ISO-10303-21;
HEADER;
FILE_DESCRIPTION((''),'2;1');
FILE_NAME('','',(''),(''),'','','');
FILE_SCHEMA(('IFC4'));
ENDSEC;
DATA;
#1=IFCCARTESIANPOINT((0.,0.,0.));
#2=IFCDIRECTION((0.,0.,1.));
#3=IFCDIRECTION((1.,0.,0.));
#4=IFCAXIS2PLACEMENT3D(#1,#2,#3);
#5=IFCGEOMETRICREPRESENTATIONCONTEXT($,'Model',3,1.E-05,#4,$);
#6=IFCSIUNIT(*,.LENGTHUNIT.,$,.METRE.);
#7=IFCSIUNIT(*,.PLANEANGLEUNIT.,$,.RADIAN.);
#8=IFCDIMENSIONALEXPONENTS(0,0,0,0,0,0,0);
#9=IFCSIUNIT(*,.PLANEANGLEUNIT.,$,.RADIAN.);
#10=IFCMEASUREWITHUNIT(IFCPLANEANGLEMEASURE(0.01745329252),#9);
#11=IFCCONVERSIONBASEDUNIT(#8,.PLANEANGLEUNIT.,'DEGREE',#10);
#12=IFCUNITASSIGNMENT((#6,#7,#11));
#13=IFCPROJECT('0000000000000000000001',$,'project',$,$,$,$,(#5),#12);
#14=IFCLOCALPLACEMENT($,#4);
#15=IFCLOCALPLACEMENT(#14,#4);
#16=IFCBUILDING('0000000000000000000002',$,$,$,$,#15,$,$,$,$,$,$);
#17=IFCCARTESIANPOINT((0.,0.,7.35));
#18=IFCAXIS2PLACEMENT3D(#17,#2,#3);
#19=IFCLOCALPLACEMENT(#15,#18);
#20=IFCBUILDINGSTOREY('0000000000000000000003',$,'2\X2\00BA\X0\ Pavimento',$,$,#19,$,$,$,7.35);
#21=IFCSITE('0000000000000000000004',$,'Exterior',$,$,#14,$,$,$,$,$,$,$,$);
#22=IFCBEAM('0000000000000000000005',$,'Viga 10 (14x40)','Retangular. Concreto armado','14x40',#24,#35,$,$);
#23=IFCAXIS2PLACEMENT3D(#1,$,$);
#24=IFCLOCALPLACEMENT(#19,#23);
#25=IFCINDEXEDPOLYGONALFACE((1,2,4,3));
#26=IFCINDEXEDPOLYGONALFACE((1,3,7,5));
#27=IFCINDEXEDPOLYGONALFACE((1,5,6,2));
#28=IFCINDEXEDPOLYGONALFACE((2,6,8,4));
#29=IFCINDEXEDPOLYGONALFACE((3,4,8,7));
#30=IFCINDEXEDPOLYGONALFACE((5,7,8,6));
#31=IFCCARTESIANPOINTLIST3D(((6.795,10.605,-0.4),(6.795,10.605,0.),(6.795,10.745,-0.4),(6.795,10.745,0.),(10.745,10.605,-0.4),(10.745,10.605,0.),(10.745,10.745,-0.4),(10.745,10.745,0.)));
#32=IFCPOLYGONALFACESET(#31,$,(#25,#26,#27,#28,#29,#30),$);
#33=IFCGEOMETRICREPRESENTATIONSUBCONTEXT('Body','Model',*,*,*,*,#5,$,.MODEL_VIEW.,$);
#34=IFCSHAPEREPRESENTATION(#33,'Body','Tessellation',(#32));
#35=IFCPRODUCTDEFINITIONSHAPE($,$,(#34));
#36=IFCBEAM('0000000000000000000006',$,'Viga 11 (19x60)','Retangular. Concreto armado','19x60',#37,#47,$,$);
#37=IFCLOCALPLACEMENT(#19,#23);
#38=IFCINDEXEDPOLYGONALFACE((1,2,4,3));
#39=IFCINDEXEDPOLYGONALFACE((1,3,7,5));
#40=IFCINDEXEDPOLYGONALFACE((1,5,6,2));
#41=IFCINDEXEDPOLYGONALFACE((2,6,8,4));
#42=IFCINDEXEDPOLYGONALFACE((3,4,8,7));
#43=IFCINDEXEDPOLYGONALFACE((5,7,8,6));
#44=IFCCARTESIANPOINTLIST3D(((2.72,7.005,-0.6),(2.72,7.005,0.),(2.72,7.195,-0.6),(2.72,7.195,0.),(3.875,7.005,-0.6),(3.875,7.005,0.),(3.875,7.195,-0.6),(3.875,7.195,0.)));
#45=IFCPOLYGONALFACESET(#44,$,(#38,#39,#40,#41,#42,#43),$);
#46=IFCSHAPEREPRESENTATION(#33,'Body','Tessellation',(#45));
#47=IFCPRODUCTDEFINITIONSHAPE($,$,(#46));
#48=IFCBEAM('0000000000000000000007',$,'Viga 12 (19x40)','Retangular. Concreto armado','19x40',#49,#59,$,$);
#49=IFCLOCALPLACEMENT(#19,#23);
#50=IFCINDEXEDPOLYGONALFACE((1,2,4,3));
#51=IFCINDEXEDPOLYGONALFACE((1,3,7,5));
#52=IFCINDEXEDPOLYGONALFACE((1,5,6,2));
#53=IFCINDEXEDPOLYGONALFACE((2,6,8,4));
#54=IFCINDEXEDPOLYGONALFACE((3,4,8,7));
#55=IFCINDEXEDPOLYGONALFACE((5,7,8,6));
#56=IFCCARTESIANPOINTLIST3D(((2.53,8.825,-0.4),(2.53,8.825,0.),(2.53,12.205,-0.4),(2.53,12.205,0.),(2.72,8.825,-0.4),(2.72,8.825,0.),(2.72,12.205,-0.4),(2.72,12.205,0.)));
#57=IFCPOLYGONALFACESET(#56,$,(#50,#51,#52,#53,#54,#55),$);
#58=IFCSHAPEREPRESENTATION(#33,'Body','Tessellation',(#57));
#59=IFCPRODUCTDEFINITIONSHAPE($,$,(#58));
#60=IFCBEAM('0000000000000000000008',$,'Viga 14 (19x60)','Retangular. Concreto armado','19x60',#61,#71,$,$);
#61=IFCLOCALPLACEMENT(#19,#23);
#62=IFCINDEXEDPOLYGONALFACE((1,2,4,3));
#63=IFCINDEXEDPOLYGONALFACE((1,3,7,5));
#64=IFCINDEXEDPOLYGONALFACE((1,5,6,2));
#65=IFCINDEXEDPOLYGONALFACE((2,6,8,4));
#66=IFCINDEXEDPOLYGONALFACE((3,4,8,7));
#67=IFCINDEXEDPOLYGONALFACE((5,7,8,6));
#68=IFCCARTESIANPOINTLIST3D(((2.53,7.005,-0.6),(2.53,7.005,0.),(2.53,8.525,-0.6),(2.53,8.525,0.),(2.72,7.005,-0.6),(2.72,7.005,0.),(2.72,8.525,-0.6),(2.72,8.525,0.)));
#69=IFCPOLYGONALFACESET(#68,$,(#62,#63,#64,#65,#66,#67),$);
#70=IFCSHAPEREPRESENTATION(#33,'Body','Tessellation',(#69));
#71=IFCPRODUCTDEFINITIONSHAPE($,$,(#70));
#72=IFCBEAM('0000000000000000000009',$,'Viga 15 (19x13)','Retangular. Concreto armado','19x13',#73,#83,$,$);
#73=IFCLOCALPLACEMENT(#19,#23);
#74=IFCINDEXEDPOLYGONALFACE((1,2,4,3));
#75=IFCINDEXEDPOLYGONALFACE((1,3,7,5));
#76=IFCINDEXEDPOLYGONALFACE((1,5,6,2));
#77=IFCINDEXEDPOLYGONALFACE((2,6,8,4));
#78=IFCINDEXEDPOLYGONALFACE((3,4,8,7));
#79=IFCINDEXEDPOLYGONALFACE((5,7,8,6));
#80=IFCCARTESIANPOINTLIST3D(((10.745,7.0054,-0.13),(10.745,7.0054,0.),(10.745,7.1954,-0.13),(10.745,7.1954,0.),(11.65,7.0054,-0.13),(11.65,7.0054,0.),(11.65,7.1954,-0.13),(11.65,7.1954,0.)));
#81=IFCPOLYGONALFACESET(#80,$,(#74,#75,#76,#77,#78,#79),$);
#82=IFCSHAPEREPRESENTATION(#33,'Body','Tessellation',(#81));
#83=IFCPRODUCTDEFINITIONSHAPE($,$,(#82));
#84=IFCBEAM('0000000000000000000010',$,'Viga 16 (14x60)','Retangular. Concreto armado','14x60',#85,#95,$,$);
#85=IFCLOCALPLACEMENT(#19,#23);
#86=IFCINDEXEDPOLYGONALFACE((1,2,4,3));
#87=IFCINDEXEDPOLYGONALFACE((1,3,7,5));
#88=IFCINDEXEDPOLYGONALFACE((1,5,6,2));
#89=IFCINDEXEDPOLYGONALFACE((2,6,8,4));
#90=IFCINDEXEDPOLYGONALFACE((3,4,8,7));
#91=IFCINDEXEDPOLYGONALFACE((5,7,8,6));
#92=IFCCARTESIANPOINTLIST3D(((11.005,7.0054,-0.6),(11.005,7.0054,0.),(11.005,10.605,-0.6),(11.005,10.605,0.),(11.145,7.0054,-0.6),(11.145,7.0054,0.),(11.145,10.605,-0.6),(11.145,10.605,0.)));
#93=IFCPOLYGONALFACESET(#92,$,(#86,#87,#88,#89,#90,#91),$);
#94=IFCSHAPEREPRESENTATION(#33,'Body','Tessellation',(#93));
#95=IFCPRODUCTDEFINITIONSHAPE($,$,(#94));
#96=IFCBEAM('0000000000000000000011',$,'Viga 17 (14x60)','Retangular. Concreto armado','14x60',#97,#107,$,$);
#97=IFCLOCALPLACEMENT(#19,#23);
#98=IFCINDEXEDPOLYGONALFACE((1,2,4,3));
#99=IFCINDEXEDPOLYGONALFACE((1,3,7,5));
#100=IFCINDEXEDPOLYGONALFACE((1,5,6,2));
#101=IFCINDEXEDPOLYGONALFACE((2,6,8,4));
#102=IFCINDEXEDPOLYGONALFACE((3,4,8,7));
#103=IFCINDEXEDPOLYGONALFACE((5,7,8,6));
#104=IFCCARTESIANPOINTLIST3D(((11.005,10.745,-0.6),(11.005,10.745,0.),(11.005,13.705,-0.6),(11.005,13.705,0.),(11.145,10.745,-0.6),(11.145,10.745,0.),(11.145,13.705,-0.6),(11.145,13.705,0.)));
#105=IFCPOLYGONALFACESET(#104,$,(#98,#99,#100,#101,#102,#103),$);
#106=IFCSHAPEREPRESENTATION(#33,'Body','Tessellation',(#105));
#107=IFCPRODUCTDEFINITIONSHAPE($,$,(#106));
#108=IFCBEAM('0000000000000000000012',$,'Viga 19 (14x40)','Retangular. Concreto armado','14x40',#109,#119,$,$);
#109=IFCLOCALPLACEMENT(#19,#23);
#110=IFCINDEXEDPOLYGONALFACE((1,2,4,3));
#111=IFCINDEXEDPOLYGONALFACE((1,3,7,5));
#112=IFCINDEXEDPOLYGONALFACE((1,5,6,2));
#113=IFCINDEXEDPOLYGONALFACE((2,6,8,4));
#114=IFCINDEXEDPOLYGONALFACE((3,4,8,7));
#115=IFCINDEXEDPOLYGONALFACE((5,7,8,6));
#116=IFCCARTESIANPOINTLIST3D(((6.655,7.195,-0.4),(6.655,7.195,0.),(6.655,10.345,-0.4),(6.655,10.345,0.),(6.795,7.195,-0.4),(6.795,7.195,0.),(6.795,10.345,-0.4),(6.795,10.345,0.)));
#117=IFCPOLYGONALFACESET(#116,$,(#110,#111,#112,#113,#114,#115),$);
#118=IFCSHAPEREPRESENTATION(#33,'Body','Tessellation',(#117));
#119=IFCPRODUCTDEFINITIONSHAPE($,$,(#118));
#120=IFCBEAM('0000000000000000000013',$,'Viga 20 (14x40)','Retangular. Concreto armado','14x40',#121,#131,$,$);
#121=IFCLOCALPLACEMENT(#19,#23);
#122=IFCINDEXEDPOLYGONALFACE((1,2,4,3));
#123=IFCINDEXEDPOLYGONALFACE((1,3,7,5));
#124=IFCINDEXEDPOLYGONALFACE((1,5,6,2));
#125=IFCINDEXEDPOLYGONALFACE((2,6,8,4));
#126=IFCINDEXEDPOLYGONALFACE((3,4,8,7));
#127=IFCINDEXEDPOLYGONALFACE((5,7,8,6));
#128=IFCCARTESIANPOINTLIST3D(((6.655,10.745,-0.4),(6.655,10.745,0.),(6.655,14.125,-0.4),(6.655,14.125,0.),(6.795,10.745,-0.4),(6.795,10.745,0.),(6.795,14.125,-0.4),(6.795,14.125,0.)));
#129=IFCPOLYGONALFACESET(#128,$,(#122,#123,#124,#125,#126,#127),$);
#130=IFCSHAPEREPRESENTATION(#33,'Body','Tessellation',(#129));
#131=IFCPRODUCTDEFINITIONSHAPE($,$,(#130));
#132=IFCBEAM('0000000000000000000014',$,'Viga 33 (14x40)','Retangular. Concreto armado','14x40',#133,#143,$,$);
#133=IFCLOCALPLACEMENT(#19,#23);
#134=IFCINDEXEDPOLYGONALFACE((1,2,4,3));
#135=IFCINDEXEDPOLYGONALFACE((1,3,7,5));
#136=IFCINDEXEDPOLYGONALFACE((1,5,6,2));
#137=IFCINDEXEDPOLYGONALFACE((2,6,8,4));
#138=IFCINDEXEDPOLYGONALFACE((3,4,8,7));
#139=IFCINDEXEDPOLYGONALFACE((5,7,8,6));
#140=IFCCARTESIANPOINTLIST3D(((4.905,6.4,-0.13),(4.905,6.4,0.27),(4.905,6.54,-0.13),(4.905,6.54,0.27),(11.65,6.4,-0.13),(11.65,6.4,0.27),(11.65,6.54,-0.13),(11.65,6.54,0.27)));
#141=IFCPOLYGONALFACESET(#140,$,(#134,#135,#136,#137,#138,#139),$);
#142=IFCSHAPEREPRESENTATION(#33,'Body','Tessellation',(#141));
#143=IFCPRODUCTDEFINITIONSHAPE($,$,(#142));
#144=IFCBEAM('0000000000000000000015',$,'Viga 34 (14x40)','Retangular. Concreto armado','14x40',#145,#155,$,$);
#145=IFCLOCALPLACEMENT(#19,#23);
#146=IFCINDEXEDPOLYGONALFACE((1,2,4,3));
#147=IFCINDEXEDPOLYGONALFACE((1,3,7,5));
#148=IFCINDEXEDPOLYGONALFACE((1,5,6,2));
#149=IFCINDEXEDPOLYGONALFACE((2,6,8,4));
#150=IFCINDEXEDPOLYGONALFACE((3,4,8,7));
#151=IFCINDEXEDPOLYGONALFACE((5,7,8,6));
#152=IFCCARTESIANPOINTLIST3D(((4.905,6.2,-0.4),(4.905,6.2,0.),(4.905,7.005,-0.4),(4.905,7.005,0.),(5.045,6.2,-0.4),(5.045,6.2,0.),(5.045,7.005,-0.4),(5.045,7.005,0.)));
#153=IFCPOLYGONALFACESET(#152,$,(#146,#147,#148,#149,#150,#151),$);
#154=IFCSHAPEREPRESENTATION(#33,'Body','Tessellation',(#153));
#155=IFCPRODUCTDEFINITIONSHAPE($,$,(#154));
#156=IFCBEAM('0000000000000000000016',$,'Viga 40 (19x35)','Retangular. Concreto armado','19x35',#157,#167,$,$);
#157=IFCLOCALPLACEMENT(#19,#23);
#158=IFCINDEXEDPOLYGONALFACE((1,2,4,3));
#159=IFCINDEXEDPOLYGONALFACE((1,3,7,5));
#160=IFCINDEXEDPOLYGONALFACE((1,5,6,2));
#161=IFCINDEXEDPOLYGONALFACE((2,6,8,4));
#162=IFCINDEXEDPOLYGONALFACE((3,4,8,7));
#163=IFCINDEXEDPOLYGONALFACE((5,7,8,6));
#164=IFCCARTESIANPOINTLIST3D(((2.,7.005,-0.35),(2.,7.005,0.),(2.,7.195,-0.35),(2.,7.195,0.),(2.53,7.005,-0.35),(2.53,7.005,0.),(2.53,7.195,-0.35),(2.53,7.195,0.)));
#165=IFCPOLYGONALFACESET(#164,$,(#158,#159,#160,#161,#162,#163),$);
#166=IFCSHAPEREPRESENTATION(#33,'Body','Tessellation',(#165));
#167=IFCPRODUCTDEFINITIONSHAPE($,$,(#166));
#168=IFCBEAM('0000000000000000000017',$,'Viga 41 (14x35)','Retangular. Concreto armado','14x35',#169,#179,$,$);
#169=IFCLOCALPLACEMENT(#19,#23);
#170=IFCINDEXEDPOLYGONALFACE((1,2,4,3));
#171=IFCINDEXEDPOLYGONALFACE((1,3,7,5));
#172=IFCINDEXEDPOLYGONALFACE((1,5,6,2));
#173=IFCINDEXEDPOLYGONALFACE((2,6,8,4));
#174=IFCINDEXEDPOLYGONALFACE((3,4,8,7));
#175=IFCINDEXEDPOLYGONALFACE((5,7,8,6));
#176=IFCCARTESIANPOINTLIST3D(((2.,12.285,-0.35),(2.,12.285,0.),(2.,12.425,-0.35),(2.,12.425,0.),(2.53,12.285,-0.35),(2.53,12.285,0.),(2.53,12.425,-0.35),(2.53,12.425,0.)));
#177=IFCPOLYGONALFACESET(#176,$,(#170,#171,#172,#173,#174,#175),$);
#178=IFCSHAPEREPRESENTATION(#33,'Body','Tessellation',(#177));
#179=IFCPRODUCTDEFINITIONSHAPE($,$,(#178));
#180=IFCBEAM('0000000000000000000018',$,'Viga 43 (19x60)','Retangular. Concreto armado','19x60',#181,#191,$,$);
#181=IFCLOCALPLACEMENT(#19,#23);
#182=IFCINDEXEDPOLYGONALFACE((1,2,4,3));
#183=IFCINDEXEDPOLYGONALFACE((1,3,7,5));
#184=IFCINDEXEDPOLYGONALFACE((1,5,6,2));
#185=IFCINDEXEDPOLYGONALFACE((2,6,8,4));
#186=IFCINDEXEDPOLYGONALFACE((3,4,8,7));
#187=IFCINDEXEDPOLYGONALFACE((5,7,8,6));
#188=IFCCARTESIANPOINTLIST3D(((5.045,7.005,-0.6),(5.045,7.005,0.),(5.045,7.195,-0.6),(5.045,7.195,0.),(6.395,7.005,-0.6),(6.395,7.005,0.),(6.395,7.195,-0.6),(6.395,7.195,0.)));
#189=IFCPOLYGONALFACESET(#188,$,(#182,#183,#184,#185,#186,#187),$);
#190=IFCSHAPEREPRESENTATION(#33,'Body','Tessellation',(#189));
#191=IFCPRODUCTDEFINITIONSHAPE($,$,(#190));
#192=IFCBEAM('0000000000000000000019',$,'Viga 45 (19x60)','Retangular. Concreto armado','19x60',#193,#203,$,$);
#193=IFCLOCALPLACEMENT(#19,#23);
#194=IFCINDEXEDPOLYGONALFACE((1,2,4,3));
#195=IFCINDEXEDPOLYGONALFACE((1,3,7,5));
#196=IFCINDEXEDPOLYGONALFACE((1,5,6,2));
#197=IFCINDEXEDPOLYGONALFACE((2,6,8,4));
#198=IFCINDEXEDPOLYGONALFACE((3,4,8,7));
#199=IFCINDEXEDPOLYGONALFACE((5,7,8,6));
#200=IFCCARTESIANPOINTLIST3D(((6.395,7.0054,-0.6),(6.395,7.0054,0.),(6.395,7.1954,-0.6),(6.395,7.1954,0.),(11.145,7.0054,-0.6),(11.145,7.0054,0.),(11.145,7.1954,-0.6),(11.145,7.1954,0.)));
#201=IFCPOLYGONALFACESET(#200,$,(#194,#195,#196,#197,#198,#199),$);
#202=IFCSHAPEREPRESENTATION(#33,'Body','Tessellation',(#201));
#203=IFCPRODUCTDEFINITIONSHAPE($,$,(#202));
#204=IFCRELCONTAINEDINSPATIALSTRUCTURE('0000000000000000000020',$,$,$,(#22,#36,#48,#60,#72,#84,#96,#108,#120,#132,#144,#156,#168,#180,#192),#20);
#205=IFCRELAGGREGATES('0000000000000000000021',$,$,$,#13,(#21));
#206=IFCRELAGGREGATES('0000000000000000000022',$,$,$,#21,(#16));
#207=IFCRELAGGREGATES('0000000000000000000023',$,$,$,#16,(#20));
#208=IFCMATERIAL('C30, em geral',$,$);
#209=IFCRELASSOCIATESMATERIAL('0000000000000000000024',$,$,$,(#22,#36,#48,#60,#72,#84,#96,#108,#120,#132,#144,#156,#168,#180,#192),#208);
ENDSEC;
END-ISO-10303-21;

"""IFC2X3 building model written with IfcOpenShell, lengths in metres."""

from ifc_helpers import new_model, entity, si_unit, converted_unit, frame, frame_2d, origin_with_axes, place, context, subcontext, project, spatial, rectangle, extrude, material, element, save


model = new_model("IFC2X3")

# Units and contexts
model_context = context("Model", 3, precision=1e-05, world=origin_with_axes())
body_context = subcontext(model_context, "Body", "Model", "MODEL_VIEW")
ifc_project = project(units=[si_unit("LENGTHUNIT", "METRE"), si_unit("PLANEANGLEUNIT", "RADIAN"), converted_unit("PLANEANGLEUNIT", "DEGREE", entity("IfcPlaneAngleMeasure", 0.01745329252), si_unit("PLANEANGLEUNIT", "RADIAN"), dimensions=[0, 0, 0, 0, 0, 0, 0])], contexts=[model_context])

# Site, building, storey
site_placement = place(None, origin_with_axes())
site = spatial("IfcSite", under=ifc_project, at=site_placement, Name="Exterior")
building_placement = place(site_placement, origin_with_axes())
building = spatial("IfcBuilding", under=site, at=building_placement)
storey_placement = place(building_placement, frame((0.0, 0.0, 7.35), z_axis=(0.0, 0.0, 1.0), x_axis=(1.0, 0.0, 0.0)))
storey = spatial("IfcBuildingStorey", under=building, at=storey_placement, Name="2º Pavimento", Elevation=7.35)

# Beams
ifc_material = material(Name="C30, em geral")
beam_1_placement = place(storey_placement, frame((6.795, 10.675, 0.0), z_axis=(1.0, 0.0, 0.0), x_axis=(0.0, 1.0, 0.0)))
element("IfcBeam", 1, at=beam_1_placement, inside=storey, material=ifc_material, Name="Viga 10 (14x40)", Description="Retangular. Concreto armado", ObjectType="14x40", context=body_context, shape_type="SweptSolid", body=[
    extrude(rectangle(XDim=0.14, YDim=0.4, at=frame_2d((0.0, -0.2), x_axis=(1.0, 0.0))), origin_with_axes(), (0.0, 0.0, 1.0), 3.95),
])
beam_2_placement = place(storey_placement, frame((2.72, 7.1, 0.0), z_axis=(1.0, 0.0, 0.0), x_axis=(0.0, 1.0, 0.0)))
element("IfcBeam", 2, at=beam_2_placement, inside=storey, material=ifc_material, Name="Viga 11 (19x60)", Description="Retangular. Concreto armado", ObjectType="19x60", context=body_context, shape_type="SweptSolid", body=[
    extrude(rectangle(XDim=0.19, YDim=0.6, at=frame_2d((0.0, -0.3), x_axis=(1.0, 0.0))), origin_with_axes(), (0.0, 0.0, 1.0), 1.155),
])
beam_3_placement = place(storey_placement, frame((2.625, 8.825, 0.0), z_axis=(0.0, 1.0, 0.0), x_axis=(-1.0, 0.0, 0.0)))
element("IfcBeam", 3, at=beam_3_placement, inside=storey, material=ifc_material, Name="Viga 12 (19x40)", Description="Retangular. Concreto armado", ObjectType="19x40", context=body_context, shape_type="SweptSolid", body=[
    extrude(rectangle(XDim=0.19, YDim=0.4, at=frame_2d((0.0, -0.2), x_axis=(1.0, 0.0))), origin_with_axes(), (0.0, 0.0, 1.0), 3.38),
])
beam_4_placement = place(storey_placement, frame((2.625, 7.005, 0.0), z_axis=(0.0, 1.0, 0.0), x_axis=(-1.0, 0.0, 0.0)))
element("IfcBeam", 4, at=beam_4_placement, inside=storey, material=ifc_material, Name="Viga 14 (19x60)", Description="Retangular. Concreto armado", ObjectType="19x60", context=body_context, shape_type="SweptSolid", body=[
    extrude(rectangle(XDim=0.19, YDim=0.6, at=frame_2d((0.0, -0.3), x_axis=(1.0, 0.0))), origin_with_axes(), (0.0, 0.0, 1.0), 1.52),
])
beam_5_placement = place(storey_placement, frame((11.65, 7.1004, 0.0), z_axis=(-1.0, 0.0, 0.0), x_axis=(0.0, -1.0, 0.0)))
element("IfcBeam", 5, at=beam_5_placement, inside=storey, material=ifc_material, Name="Viga 15 (19x13)", Description="Retangular. Concreto armado", ObjectType="19x13", context=body_context, shape_type="SweptSolid", body=[
    extrude(rectangle(XDim=0.19, YDim=0.13, at=frame_2d((0.0, -0.065), x_axis=(1.0, 0.0))), origin_with_axes(), (0.0, 0.0, 1.0), 0.905),
])
beam_6_placement = place(storey_placement, frame((11.075, 7.0054, 0.0), z_axis=(0.0, 1.0, 0.0), x_axis=(-1.0, 0.0, 0.0)))
element("IfcBeam", 6, at=beam_6_placement, inside=storey, material=ifc_material, Name="Viga 16 (14x60)", Description="Retangular. Concreto armado", ObjectType="14x60", context=body_context, shape_type="SweptSolid", body=[
    extrude(rectangle(XDim=0.14, YDim=0.6, at=frame_2d((0.0, -0.3), x_axis=(1.0, 0.0))), origin_with_axes(), (0.0, 0.0, 1.0), 3.5996),
])
beam_7_placement = place(storey_placement, frame((11.075, 10.745, 0.0), z_axis=(0.0, 1.0, 0.0), x_axis=(-1.0, 0.0, 0.0)))
element("IfcBeam", 7, at=beam_7_placement, inside=storey, material=ifc_material, Name="Viga 17 (14x60)", Description="Retangular. Concreto armado", ObjectType="14x60", context=body_context, shape_type="SweptSolid", body=[
    extrude(rectangle(XDim=0.14, YDim=0.6, at=frame_2d((0.0, -0.3), x_axis=(1.0, 0.0))), origin_with_axes(), (0.0, 0.0, 1.0), 2.96),
])
beam_8_placement = place(storey_placement, frame((6.725, 7.195, 0.0), z_axis=(0.0, 1.0, 0.0), x_axis=(-1.0, 0.0, 0.0)))
element("IfcBeam", 8, at=beam_8_placement, inside=storey, material=ifc_material, Name="Viga 19 (14x40)", Description="Retangular. Concreto armado", ObjectType="14x40", context=body_context, shape_type="SweptSolid", body=[
    extrude(rectangle(XDim=0.14, YDim=0.4, at=frame_2d((0.0, -0.2), x_axis=(1.0, 0.0))), origin_with_axes(), (0.0, 0.0, 1.0), 3.15),
])
beam_9_placement = place(storey_placement, frame((6.725, 10.745, 0.0), z_axis=(0.0, 1.0, 0.0), x_axis=(-1.0, 0.0, 0.0)))
element("IfcBeam", 9, at=beam_9_placement, inside=storey, material=ifc_material, Name="Viga 20 (14x40)", Description="Retangular. Concreto armado", ObjectType="14x40", context=body_context, shape_type="SweptSolid", body=[
    extrude(rectangle(XDim=0.14, YDim=0.4, at=frame_2d((0.0, -0.2), x_axis=(1.0, 0.0))), origin_with_axes(), (0.0, 0.0, 1.0), 3.38),
])
beam_10_placement = place(storey_placement, frame((4.905, 6.47, 0.27), z_axis=(1.0, 0.0, 0.0), x_axis=(0.0, 1.0, 0.0)))
element("IfcBeam", 10, at=beam_10_placement, inside=storey, material=ifc_material, Name="Viga 33 (14x40)", Description="Retangular. Concreto armado", ObjectType="14x40", context=body_context, shape_type="SweptSolid", body=[
    extrude(rectangle(XDim=0.14, YDim=0.4, at=frame_2d((0.0, -0.2), x_axis=(1.0, 0.0))), origin_with_axes(), (0.0, 0.0, 1.0), 6.745),
])
beam_11_placement = place(storey_placement, frame((4.975, 7.005, 0.0), z_axis=(0.0, -1.0, 0.0), x_axis=(1.0, 0.0, 0.0)))
element("IfcBeam", 11, at=beam_11_placement, inside=storey, material=ifc_material, Name="Viga 34 (14x40)", Description="Retangular. Concreto armado", ObjectType="14x40", context=body_context, shape_type="SweptSolid", body=[
    extrude(rectangle(XDim=0.14, YDim=0.4, at=frame_2d((0.0, -0.2), x_axis=(1.0, 0.0))), origin_with_axes(), (0.0, 0.0, 1.0), 0.805),
])
beam_12_placement = place(storey_placement, frame((2.0, 7.1, 0.0), z_axis=(1.0, 0.0, 0.0), x_axis=(0.0, 1.0, 0.0)))
element("IfcBeam", 12, at=beam_12_placement, inside=storey, material=ifc_material, Name="Viga 40 (19x35)", Description="Retangular. Concreto armado", ObjectType="19x35", context=body_context, shape_type="SweptSolid", body=[
    extrude(rectangle(XDim=0.19, YDim=0.35, at=frame_2d((0.0, -0.175), x_axis=(1.0, 0.0))), origin_with_axes(), (0.0, 0.0, 1.0), 0.53),
])
beam_13_placement = place(storey_placement, frame((2.53, 12.355, 0.0), z_axis=(-1.0, 0.0, 0.0), x_axis=(0.0, -1.0, 0.0)))
element("IfcBeam", 13, at=beam_13_placement, inside=storey, material=ifc_material, Name="Viga 41 (14x35)", Description="Retangular. Concreto armado", ObjectType="14x35", context=body_context, shape_type="SweptSolid", body=[
    extrude(rectangle(XDim=0.14, YDim=0.35, at=frame_2d((0.0, -0.175), x_axis=(1.0, 0.0))), origin_with_axes(), (0.0, 0.0, 1.0), 0.53),
])
beam_14_placement = place(storey_placement, frame((5.045, 7.1, 0.0), z_axis=(1.0, 0.0, 0.0), x_axis=(0.0, 1.0, 0.0)))
element("IfcBeam", 14, at=beam_14_placement, inside=storey, material=ifc_material, Name="Viga 43 (19x60)", Description="Retangular. Concreto armado", ObjectType="19x60", context=body_context, shape_type="SweptSolid", body=[
    extrude(rectangle(XDim=0.19, YDim=0.6, at=frame_2d((0.0, -0.3), x_axis=(1.0, 0.0))), origin_with_axes(), (0.0, 0.0, 1.0), 1.35),
])
beam_15_placement = place(storey_placement, frame((11.145, 7.1004, 0.0), z_axis=(-1.0, 0.0, 0.0), x_axis=(0.0, -1.0, 0.0)))
element("IfcBeam", 15, at=beam_15_placement, inside=storey, material=ifc_material, Name="Viga 45 (19x60)", Description="Retangular. Concreto armado", ObjectType="19x60", context=body_context, shape_type="SweptSolid", body=[
    extrude(rectangle(XDim=0.19, YDim=0.6, at=frame_2d((0.0, -0.3), x_axis=(1.0, 0.0))), origin_with_axes(), (0.0, 0.0, 1.0), 4.75),
])

save(model, "model.ifc")
